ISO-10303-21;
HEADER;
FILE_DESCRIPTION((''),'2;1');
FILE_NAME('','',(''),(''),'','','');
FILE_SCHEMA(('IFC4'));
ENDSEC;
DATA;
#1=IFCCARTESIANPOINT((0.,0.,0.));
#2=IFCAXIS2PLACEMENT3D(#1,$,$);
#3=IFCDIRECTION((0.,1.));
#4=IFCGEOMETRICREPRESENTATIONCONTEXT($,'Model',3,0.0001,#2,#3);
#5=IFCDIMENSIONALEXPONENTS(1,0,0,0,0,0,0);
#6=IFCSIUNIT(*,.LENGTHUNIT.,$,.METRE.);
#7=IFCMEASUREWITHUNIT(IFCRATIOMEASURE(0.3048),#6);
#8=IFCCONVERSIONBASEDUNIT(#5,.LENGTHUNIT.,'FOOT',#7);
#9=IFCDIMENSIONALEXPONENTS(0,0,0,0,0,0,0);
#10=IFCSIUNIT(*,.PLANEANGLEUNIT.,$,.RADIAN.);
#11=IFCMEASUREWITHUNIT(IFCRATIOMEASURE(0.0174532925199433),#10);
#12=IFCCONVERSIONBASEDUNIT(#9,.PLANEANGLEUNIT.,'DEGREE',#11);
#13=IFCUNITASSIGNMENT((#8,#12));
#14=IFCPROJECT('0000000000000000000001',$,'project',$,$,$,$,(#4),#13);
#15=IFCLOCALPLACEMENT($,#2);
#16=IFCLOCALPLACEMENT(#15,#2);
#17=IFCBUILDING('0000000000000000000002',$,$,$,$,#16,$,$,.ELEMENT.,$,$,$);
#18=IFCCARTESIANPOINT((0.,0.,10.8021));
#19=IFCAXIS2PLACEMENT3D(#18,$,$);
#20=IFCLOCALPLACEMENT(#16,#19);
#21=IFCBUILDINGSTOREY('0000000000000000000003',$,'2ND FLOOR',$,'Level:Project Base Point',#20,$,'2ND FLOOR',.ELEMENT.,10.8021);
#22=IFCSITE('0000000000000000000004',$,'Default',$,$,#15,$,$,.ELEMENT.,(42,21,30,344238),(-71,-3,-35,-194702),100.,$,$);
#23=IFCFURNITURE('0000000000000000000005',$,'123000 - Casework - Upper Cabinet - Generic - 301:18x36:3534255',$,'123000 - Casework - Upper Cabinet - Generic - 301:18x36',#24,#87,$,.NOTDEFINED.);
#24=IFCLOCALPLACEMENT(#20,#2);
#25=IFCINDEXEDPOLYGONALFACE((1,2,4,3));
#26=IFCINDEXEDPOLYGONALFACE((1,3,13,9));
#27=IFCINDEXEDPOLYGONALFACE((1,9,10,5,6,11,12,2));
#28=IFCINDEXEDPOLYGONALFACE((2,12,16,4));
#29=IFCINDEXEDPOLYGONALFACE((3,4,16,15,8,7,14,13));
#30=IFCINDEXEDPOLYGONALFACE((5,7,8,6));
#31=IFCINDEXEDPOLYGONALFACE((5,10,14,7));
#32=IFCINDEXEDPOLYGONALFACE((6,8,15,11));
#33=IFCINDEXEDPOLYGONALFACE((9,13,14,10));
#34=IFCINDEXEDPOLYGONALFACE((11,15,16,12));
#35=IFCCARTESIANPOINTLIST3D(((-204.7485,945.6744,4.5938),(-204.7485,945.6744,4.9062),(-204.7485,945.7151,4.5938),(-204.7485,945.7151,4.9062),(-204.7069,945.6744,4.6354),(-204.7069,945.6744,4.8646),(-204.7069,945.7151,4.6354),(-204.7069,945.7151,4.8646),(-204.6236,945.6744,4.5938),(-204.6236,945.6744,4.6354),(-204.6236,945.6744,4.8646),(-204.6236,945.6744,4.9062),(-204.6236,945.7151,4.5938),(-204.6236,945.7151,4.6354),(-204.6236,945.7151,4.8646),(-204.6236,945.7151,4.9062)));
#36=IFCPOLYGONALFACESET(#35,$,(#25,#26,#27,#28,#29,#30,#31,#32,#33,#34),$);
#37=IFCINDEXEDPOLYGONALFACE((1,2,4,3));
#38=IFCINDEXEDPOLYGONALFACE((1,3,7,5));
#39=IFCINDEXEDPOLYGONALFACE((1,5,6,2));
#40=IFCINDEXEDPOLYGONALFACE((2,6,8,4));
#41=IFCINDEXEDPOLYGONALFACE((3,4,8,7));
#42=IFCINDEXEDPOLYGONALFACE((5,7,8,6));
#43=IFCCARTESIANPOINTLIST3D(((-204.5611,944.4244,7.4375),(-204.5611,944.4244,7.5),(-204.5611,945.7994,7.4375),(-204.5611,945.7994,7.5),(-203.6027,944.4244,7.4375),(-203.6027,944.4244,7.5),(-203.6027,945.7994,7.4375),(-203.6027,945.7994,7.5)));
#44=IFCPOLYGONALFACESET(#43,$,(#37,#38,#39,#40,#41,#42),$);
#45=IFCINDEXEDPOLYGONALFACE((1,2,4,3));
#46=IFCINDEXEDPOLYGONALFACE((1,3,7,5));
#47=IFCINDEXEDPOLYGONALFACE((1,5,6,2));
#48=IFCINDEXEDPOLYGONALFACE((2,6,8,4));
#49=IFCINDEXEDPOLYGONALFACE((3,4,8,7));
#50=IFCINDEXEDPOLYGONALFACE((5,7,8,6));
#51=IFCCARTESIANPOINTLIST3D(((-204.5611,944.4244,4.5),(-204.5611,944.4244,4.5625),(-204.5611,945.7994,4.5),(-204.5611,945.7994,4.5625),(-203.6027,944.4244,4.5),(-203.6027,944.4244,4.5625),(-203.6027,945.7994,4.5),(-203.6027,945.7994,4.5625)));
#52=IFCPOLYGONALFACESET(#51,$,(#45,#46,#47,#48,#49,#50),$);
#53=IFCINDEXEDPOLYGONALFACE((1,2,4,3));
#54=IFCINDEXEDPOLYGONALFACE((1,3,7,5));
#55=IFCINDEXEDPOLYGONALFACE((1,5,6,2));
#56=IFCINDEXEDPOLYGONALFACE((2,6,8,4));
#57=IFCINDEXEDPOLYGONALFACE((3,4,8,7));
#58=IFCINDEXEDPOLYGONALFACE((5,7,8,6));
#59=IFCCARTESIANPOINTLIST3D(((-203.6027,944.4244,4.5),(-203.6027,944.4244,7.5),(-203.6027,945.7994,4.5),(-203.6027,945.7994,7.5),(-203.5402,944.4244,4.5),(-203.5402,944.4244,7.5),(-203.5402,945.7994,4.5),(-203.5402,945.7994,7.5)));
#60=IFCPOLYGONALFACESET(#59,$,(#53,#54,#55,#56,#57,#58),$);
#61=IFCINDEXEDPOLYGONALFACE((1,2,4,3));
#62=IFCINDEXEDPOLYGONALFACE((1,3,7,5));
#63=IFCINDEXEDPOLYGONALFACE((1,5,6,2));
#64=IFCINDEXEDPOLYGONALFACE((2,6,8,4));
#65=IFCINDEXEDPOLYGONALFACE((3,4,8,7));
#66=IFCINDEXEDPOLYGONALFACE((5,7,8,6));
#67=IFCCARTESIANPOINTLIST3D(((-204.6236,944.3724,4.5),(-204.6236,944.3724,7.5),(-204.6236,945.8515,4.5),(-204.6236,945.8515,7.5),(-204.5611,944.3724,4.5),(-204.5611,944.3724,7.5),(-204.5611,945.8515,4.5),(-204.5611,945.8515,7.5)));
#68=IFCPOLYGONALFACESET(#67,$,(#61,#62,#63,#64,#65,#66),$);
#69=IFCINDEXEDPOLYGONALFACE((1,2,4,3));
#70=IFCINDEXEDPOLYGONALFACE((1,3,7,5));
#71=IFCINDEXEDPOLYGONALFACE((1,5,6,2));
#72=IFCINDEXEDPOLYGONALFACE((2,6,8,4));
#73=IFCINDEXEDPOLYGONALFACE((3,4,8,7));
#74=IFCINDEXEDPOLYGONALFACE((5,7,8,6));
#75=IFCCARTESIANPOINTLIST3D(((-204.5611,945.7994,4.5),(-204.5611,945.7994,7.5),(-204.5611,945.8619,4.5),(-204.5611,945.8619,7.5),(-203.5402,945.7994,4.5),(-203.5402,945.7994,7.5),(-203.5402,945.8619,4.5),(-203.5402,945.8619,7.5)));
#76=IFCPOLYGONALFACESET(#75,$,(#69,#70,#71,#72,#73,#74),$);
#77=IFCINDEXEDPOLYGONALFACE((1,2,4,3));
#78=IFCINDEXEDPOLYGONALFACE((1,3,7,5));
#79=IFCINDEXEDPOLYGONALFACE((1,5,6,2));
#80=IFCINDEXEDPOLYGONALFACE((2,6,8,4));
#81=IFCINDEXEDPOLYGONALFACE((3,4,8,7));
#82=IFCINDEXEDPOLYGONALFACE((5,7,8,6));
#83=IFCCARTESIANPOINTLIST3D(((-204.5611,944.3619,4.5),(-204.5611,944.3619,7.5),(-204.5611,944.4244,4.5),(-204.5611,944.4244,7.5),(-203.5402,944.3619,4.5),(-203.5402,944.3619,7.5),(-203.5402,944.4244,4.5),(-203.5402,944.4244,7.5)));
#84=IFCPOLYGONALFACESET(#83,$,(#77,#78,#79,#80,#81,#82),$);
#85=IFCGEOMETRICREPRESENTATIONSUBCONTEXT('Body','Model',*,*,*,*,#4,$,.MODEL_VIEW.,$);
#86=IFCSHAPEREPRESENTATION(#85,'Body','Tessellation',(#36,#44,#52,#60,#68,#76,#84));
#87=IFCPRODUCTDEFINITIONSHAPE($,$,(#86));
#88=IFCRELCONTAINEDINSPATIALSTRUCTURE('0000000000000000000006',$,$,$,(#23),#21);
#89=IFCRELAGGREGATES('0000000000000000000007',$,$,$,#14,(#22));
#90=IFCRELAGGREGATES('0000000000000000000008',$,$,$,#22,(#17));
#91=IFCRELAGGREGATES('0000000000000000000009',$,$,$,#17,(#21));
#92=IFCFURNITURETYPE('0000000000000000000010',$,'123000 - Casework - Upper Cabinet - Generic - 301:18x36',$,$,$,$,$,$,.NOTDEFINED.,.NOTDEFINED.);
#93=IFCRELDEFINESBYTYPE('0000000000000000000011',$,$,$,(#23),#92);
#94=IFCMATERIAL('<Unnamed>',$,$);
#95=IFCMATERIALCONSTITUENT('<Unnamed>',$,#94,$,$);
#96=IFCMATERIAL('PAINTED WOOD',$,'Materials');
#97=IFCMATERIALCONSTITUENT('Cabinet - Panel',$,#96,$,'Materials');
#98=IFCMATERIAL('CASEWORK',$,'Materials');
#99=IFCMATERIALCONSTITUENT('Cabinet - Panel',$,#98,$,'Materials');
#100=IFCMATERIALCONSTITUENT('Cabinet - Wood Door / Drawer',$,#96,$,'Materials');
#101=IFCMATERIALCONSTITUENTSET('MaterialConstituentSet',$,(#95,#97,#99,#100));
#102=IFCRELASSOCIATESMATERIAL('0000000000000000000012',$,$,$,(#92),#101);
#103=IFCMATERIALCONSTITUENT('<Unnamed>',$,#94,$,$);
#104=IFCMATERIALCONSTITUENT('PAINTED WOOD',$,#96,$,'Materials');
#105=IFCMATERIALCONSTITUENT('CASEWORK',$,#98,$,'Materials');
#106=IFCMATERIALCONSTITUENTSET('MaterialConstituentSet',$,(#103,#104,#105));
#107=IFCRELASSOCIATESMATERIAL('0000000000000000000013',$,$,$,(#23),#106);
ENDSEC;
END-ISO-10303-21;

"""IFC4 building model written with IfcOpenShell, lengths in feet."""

from ifc_helpers import new_model, entity, si_unit, converted_unit, direction, frame, frame_2d, origin, origin_2d_with_axis, place, context, subcontext, project, spatial, polyline, rectangle, outline, extrude, source, transform, mapped, material, constituent, constituent_set, type_object, type_shapes, element, save


model = new_model("IFC4")

# Units and contexts
model_context = context("Model", 3, precision=0.0001, world=origin(), true_north=direction((0.0, 1.0)))
body_context = subcontext(model_context, "Body", "Model", "MODEL_VIEW")
ifc_project = project(units=[converted_unit("LENGTHUNIT", "FOOT", entity("IfcRatioMeasure", 0.3048), si_unit("LENGTHUNIT", "METRE"), dimensions=[1, 0, 0, 0, 0, 0, 0]), converted_unit("PLANEANGLEUNIT", "DEGREE", entity("IfcRatioMeasure", 0.0174532925199433), si_unit("PLANEANGLEUNIT", "RADIAN"), dimensions=[0, 0, 0, 0, 0, 0, 0])], contexts=[model_context])

# Site, building, storey
site_placement = place(None, origin())
site = spatial("IfcSite", under=ifc_project, at=site_placement, Name="Default", CompositionType="ELEMENT", RefLatitude=(42, 21, 30, 344238), RefLongitude=(-71, -3, -35, -194702), RefElevation=100.0)
building_placement = place(site_placement, origin())
building = spatial("IfcBuilding", under=site, at=building_placement, CompositionType="ELEMENT")
storey_placement = place(building_placement, frame((0.0, 0.0, 10.8021)))
storey = spatial("IfcBuildingStorey", under=building, at=storey_placement, Name="2ND FLOOR", ObjectType="Level:Project Base Point", LongName="2ND FLOOR", CompositionType="ELEMENT", Elevation=10.8021)

# Furniture
ifc_material_1 = material(Name="CASEWORK", Category="Materials")
ifc_material_2 = material(Name="<Unnamed>")
ifc_material_3 = material(Name="PAINTED WOOD", Category="Materials")
ifc_constituent_1 = constituent(ifc_material_2, Name="<Unnamed>")
ifc_constituent_2 = constituent(ifc_material_3, Name="PAINTED WOOD", Category="Materials")
ifc_constituent_3 = constituent(ifc_material_1, Name="CASEWORK", Category="Materials")
ifc_constituent_set_1 = constituent_set(constituents=[ifc_constituent_1, ifc_constituent_2, ifc_constituent_3], Name="MaterialConstituentSet")
ifc_constituent_4 = constituent(ifc_material_2, Name="<Unnamed>")
ifc_constituent_5 = constituent(ifc_material_3, Name="Cabinet - Panel", Category="Materials")
ifc_constituent_6 = constituent(ifc_material_1, Name="Cabinet - Panel", Category="Materials")
ifc_constituent_7 = constituent(ifc_material_3, Name="Cabinet - Wood Door / Drawer", Category="Materials")
ifc_constituent_set_2 = constituent_set(constituents=[ifc_constituent_4, ifc_constituent_5, ifc_constituent_6, ifc_constituent_7], Name="MaterialConstituentSet")
furniture_type_1 = type_object("IfcFurnitureType", Name="123000 - Casework - Upper Cabinet - Generic - 301:18x36", AssemblyPlace="NOTDEFINED", PredefinedType="NOTDEFINED", material=ifc_constituent_set_2)
shared_shape_1 = source(origin(), body_context, "Body", "SweptSolid", [
    extrude(outline(polyline([(0.1146, -0.0521), (0.1562, -0.0521), (0.1562, 0.0729), (-0.1562, 0.0729), (-0.1562, -0.0521), (-0.1146, -0.0521), (-0.1146, 0.0313), (0.1146, 0.0313), (0.1146, -0.0521)])), frame((0.1468, 0.0729, 0.25), z_axis=(1.0, 0.0, 0.0), x_axis=(0.0, 0.0, 1.0)), (0.0, 0.0, 1.0), 0.0407),
    extrude(rectangle(XDim=1.375, YDim=0.9583, at=frame_2d((0.0, 0.0), x_axis=(1.0, 0.0))), frame((0.75, 0.6666, 2.9375), z_axis=(0.0, 0.0, 1.0), x_axis=(-1.0, 0.0, 0.0)), (0.0, 0.0, 1.0), 0.0625),
    extrude(rectangle(XDim=1.375, YDim=0.9583, at=frame_2d((0.0, 0.0), x_axis=(1.0, 0.0))), frame((0.75, 0.6666, 0.0), z_axis=(0.0, 0.0, 1.0), x_axis=(-1.0, 0.0, 0.0)), (0.0, 0.0, 1.0), 0.0625),
    extrude(rectangle(XDim=0.0625, YDim=1.375, at=origin_2d_with_axis()), frame((0.75, 1.177, 0.0), z_axis=(0.0, 0.0, 1.0), x_axis=(0.0, 1.0, 0.0)), (0.0, 0.0, 1.0), 3.0),
    extrude(rectangle(XDim=0.0625, YDim=1.4792, at=origin_2d_with_axis()), frame((0.75, 0.1562, 0.0), z_axis=(0.0, 0.0, 1.0), x_axis=(0.0, -1.0, 0.0)), (0.0, 0.0, 1.0), 3.0),
    extrude(rectangle(XDim=0.0625, YDim=1.0208, at=origin_2d_with_axis()), frame((0.0312, 0.6979, 0.0), z_axis=(0.0, 0.0, 1.0), x_axis=(-1.0, 0.0, 0.0)), (0.0, 0.0, 1.0), 3.0),
    extrude(rectangle(XDim=0.0625, YDim=1.0208, at=origin_2d_with_axis()), frame((1.4688, 0.6979, 0.0), z_axis=(0.0, 0.0, 1.0), x_axis=(-1.0, 0.0, 0.0)), (0.0, 0.0, 1.0), 3.0),
])
type_shapes(furniture_type_1, [shared_shape_1])
furniture_1_placement = place(storey_placement, frame((-204.7485, 945.8619, 4.5), z_axis=(0.0, 0.0, 1.0), x_axis=(0.0, -1.0, 0.0)))
element("IfcFurniture", 1, at=furniture_1_placement, inside=storey, type_object=furniture_type_1, material=ifc_constituent_set_1, Name="123000 - Casework - Upper Cabinet - Generic - 301:18x36:3534255", ObjectType="123000 - Casework - Upper Cabinet - Generic - 301:18x36", PredefinedType="NOTDEFINED", context=body_context, shape_type="MappedRepresentation", body=[
    mapped(shared_shape_1, transform((0.0, 0.0, 0.0), scale=1.0)),
])

save(model, "model.ifc")
